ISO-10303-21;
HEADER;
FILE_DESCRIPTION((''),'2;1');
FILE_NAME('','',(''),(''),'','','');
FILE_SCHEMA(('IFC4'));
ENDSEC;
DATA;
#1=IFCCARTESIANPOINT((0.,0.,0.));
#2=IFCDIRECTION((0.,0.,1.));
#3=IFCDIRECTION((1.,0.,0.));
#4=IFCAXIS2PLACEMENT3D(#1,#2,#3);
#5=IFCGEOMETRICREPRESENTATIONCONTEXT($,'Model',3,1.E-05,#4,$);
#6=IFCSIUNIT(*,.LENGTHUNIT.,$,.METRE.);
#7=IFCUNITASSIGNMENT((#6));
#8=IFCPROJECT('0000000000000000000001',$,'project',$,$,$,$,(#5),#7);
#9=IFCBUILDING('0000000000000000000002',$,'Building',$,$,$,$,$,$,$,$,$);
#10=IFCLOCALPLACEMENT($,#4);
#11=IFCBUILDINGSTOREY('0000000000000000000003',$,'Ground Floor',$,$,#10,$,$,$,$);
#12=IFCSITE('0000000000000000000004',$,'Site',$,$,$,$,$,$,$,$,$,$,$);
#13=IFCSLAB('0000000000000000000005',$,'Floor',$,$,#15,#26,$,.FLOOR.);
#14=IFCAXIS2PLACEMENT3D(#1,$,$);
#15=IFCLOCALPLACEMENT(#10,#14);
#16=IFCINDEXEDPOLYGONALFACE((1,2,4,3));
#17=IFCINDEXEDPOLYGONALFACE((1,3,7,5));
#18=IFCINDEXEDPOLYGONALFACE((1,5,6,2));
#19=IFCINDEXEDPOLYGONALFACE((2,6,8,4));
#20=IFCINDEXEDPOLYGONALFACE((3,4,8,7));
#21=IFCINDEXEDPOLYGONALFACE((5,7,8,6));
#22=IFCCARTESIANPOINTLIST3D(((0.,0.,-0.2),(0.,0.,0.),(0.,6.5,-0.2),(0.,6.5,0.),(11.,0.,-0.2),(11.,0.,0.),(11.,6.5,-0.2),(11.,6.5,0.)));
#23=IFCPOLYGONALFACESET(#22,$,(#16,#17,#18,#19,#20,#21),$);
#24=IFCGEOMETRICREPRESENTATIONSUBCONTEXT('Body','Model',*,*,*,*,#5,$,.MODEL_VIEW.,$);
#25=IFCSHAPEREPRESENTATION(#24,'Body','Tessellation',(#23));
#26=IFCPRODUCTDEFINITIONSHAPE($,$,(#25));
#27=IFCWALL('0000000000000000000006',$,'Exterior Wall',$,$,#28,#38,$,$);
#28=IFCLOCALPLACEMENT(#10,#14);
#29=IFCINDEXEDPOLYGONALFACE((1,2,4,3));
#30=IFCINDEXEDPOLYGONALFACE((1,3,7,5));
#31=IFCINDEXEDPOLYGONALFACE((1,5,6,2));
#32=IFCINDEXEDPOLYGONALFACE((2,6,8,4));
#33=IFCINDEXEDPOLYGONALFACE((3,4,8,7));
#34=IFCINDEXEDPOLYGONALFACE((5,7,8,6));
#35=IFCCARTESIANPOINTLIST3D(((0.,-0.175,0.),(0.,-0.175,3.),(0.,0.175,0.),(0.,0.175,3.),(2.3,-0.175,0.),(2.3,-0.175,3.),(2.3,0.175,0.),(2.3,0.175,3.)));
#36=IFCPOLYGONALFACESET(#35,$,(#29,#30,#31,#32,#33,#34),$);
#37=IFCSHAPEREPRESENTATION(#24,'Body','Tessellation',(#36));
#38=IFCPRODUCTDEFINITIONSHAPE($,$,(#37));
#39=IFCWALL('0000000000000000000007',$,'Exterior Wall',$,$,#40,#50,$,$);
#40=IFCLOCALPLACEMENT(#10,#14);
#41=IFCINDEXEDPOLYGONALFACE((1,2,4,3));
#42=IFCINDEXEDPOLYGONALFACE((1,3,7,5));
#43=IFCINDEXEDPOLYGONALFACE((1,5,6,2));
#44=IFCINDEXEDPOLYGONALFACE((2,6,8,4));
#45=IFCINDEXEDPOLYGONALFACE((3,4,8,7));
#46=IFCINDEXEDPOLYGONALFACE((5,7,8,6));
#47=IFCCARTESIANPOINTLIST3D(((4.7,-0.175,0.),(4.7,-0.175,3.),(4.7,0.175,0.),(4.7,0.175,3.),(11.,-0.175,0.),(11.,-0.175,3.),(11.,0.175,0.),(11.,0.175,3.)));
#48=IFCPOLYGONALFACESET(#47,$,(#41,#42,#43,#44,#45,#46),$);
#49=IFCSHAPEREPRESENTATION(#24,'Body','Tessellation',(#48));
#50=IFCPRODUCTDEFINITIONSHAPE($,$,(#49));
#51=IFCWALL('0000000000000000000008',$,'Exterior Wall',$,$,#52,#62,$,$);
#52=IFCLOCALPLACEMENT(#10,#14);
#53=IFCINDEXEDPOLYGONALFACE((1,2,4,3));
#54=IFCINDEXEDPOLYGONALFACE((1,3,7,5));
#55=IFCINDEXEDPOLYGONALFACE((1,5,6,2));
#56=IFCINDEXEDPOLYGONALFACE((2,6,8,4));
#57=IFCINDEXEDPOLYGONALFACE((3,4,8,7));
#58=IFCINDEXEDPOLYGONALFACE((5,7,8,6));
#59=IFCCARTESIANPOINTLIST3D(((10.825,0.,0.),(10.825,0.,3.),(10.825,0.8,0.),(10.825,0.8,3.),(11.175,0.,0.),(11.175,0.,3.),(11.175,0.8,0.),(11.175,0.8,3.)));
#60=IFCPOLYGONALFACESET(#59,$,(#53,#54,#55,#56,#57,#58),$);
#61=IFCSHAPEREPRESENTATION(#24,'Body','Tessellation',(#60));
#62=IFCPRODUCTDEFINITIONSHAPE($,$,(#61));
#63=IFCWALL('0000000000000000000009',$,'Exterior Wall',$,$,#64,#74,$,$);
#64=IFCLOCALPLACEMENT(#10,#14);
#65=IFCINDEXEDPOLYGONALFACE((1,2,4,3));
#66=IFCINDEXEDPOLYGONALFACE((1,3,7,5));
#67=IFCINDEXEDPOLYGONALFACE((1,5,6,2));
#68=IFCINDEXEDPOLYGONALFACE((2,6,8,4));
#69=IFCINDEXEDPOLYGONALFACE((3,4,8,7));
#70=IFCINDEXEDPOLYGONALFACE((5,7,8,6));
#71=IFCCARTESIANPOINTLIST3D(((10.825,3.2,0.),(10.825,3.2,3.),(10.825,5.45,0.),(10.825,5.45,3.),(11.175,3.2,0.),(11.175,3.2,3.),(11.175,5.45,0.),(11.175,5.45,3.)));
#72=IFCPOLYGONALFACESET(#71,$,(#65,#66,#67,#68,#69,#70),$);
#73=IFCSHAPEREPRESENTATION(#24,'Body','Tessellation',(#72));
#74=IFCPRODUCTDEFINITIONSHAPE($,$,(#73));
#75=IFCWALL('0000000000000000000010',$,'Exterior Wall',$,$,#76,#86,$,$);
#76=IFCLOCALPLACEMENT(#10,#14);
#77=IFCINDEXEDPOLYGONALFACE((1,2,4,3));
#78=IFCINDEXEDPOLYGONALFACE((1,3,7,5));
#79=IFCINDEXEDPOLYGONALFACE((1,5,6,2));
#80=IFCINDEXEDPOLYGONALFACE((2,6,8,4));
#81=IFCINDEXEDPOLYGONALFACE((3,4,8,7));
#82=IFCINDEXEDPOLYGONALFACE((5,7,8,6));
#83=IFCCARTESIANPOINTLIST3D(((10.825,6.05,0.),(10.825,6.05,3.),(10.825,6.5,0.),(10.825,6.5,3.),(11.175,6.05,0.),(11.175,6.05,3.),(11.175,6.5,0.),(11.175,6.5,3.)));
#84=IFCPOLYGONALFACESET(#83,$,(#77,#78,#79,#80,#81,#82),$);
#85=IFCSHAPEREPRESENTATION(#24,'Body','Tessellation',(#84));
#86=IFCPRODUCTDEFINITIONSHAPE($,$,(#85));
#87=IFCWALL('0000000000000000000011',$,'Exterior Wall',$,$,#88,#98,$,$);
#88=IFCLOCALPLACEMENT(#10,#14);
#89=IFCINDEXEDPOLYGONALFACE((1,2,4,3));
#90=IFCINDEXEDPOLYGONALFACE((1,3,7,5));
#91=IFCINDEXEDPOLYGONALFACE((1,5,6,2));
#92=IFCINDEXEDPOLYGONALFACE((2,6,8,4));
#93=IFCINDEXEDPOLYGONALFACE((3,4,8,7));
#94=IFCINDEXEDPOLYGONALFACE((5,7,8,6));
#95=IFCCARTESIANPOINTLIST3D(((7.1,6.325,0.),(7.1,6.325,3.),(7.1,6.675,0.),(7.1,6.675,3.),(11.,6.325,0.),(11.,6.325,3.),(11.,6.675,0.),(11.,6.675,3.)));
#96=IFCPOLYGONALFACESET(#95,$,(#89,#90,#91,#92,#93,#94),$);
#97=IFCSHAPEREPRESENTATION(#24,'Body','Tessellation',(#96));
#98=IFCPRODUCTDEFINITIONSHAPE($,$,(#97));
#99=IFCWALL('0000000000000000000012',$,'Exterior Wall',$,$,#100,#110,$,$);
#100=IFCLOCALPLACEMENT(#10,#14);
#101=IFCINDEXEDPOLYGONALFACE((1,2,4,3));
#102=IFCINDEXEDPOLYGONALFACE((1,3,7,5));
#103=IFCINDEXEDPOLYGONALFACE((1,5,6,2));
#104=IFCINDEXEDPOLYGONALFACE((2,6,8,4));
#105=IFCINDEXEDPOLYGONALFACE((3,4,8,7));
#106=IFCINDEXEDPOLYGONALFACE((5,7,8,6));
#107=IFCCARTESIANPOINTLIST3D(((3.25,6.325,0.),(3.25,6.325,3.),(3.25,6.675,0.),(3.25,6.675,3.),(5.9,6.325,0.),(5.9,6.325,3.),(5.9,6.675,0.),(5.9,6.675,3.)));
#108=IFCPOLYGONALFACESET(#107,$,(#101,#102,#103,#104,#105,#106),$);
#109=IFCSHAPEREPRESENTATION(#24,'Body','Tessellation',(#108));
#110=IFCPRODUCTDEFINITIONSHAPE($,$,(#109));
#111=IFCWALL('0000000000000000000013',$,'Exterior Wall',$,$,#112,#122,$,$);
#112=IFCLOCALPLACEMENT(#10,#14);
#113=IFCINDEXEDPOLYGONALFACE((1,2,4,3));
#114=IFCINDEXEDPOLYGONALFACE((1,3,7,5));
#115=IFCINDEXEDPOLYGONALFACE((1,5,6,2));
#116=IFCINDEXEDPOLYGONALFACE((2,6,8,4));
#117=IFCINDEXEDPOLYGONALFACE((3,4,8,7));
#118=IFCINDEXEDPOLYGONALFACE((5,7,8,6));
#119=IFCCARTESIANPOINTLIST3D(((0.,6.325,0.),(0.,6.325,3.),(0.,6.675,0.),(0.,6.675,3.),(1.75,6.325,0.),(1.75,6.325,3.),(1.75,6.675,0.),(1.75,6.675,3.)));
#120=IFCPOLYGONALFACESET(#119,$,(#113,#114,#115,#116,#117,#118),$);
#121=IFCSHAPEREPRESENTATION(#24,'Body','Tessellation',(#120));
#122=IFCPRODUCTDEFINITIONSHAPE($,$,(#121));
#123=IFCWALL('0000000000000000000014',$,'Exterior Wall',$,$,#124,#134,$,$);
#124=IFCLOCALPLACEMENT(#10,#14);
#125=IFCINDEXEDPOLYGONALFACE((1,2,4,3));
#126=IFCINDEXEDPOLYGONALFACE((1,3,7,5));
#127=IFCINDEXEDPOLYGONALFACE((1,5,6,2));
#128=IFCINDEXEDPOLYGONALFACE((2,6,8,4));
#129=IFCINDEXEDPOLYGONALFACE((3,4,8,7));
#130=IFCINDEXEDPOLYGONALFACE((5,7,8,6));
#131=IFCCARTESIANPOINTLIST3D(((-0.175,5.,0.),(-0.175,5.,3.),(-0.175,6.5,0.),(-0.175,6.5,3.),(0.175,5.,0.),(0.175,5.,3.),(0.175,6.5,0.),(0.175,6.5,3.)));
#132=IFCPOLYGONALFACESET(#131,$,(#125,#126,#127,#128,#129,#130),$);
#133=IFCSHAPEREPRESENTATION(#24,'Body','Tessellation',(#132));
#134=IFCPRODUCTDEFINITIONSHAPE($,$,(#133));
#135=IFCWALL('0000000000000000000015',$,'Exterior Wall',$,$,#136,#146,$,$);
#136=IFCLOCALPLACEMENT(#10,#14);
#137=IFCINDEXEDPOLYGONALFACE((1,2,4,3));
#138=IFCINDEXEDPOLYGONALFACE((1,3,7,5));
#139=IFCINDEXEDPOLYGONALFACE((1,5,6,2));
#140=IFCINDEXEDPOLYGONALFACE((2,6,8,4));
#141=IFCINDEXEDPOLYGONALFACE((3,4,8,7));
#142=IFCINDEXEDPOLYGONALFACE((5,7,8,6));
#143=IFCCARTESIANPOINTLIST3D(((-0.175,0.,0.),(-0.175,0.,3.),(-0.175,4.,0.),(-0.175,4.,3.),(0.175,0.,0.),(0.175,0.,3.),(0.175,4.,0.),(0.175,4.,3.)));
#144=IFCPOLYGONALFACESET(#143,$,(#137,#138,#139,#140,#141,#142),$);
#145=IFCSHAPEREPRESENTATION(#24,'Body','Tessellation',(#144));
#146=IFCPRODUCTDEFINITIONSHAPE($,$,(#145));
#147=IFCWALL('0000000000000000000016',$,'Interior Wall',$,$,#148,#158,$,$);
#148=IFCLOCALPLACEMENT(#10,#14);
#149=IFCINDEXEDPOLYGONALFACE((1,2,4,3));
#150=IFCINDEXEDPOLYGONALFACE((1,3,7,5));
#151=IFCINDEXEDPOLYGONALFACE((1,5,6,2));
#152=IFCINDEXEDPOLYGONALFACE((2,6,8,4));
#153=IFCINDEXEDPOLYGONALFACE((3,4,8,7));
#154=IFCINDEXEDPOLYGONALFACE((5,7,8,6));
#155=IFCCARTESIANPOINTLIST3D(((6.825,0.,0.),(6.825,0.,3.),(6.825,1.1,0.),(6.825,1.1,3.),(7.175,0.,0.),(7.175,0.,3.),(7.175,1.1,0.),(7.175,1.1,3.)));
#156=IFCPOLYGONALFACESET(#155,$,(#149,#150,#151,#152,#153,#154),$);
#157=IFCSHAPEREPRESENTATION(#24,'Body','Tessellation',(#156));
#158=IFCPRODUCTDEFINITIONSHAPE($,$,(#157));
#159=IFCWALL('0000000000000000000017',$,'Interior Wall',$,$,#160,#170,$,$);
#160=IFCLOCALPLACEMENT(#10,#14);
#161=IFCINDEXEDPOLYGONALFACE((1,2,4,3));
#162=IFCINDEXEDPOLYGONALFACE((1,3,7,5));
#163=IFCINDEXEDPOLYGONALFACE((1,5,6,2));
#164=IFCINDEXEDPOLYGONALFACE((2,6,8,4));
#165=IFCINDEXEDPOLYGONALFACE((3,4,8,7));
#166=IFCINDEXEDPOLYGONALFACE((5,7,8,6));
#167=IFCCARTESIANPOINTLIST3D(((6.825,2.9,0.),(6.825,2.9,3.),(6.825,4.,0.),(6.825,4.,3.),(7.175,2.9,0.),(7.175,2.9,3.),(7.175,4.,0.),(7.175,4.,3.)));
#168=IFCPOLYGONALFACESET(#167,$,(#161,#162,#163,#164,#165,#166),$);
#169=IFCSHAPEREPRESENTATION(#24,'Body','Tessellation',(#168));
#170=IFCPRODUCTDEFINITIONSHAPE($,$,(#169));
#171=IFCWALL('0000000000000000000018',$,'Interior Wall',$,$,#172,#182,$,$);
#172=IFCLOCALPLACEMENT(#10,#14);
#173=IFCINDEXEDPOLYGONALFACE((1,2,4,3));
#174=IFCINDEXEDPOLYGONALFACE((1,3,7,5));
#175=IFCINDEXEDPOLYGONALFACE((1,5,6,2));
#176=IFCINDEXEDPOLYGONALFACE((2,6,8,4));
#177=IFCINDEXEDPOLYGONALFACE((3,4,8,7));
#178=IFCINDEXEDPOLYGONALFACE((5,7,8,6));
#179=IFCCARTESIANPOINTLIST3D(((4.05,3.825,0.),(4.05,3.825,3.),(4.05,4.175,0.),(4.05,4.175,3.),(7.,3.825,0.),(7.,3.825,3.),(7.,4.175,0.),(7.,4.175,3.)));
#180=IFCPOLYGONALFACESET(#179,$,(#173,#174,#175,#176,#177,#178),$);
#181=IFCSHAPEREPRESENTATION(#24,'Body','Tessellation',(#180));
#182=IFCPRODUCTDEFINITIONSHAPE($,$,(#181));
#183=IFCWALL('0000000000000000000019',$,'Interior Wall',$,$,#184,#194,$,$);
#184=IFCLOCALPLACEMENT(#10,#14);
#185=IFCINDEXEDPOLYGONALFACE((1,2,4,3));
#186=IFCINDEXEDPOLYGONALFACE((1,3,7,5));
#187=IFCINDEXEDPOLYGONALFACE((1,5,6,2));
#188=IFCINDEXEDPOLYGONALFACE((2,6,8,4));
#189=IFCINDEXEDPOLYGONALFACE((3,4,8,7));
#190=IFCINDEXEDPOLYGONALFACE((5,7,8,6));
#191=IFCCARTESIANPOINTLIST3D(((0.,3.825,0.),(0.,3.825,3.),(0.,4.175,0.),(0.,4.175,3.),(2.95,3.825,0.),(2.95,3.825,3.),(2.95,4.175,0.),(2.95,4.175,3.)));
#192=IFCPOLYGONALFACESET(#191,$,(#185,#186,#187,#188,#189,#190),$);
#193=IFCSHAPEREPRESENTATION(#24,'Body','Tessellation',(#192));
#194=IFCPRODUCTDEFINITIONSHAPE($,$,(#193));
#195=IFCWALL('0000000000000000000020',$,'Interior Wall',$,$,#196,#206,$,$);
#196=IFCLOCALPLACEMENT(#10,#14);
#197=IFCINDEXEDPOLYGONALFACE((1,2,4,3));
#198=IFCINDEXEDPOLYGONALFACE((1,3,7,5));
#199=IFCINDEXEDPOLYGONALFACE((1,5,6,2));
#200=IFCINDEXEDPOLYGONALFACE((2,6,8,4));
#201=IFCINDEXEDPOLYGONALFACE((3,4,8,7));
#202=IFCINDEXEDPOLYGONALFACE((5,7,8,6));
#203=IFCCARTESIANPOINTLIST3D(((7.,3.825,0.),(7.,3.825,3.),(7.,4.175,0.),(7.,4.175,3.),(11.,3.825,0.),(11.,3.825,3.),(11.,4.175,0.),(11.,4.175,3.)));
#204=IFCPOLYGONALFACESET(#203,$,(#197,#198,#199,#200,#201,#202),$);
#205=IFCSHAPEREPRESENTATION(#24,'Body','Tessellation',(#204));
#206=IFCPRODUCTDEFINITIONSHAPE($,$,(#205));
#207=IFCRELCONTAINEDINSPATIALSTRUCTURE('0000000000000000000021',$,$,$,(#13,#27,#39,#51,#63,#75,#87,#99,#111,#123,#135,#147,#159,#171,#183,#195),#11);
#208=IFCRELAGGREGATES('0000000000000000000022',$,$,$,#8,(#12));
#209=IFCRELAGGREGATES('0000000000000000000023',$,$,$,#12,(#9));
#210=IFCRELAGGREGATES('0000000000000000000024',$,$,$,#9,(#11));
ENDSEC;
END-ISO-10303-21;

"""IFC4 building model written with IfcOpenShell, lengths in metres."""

from ifc_helpers import new_model, si_unit, frame, origin_with_axes, place, context, subcontext, project, spatial, indexed_curve, outline, extrude, element, save


model = new_model("IFC4")

# Units and contexts
model_context = context("Model", 3, precision=1e-05, world=origin_with_axes())
body_context = subcontext(model_context, "Body", "Model", "MODEL_VIEW")
ifc_project = project(units=[si_unit("LENGTHUNIT", "METRE")], contexts=[model_context])

# Site, building, storey
site = spatial("IfcSite", under=ifc_project, Name="Site")
building = spatial("IfcBuilding", under=site, Name="Building")
storey_placement = place(None, origin_with_axes())
storey = spatial("IfcBuildingStorey", under=building, at=storey_placement, Name="Ground Floor")

# Slab
slab_placement = place(storey_placement, frame((0.0, 0.0, -0.2), z_axis=(0.0, 0.0, 1.0), x_axis=(1.0, 0.0, 0.0)))
element("IfcSlab", 1, at=slab_placement, inside=storey, Name="Floor", PredefinedType="FLOOR", context=body_context, shape_type="SweptSolid", body=[
    extrude(outline(indexed_curve([(0.0, 0.0), (11.0, 0.0), (11.0, 6.5), (0.0, 6.5)])), None, (0.0, 0.0, 1.0), 0.2),
])

# Walls
wall_1_placement = place(storey_placement, origin_with_axes())
element("IfcWall", 2, at=wall_1_placement, inside=storey, Name="Exterior Wall", context=body_context, shape_type="SweptSolid", body=[
    extrude(outline(indexed_curve([(0.0, 0.0), (0.0, 0.35), (2.3, 0.35), (2.3, 0.0), (0.0, 0.0)], self_intersect=False)), frame((0.0, -0.175, 0.0), z_axis=(0.0, 0.0, 1.0), x_axis=(1.0, 0.0, 0.0)), (0.0, 0.0, 1.0), 3.0),
])
wall_2_placement = place(storey_placement, frame((4.7, 0.0, 0.0), z_axis=(0.0, 0.0, 1.0), x_axis=(1.0, 0.0, 0.0)))
element("IfcWall", 3, at=wall_2_placement, inside=storey, Name="Exterior Wall", context=body_context, shape_type="SweptSolid", body=[
    extrude(outline(indexed_curve([(0.0, 0.0), (0.0, 0.35), (6.3, 0.35), (6.3, 0.0), (0.0, 0.0)], self_intersect=False)), frame((0.0, -0.175, 0.0), z_axis=(0.0, 0.0, 1.0), x_axis=(1.0, 0.0, 0.0)), (0.0, 0.0, 1.0), 3.0),
])
wall_3_placement = place(storey_placement, frame((11.0, 0.0, 0.0), z_axis=(0.0, 0.0, 1.0), x_axis=(0.0, 1.0, 0.0)))
element("IfcWall", 4, at=wall_3_placement, inside=storey, Name="Exterior Wall", context=body_context, shape_type="SweptSolid", body=[
    extrude(outline(indexed_curve([(0.0, 0.0), (0.0, 0.35), (0.8, 0.35), (0.8, 0.0), (0.0, 0.0)], self_intersect=False)), frame((0.0, -0.175, 0.0), z_axis=(0.0, 0.0, 1.0), x_axis=(1.0, 0.0, 0.0)), (0.0, 0.0, 1.0), 3.0),
])
wall_4_placement = place(storey_placement, frame((11.0, 3.2, 0.0), z_axis=(0.0, 0.0, 1.0), x_axis=(0.0, 1.0, 0.0)))
element("IfcWall", 5, at=wall_4_placement, inside=storey, Name="Exterior Wall", context=body_context, shape_type="SweptSolid", body=[
    extrude(outline(indexed_curve([(0.0, 0.0), (0.0, 0.35), (2.25, 0.35), (2.25, 0.0), (0.0, 0.0)], self_intersect=False)), frame((0.0, -0.175, 0.0), z_axis=(0.0, 0.0, 1.0), x_axis=(1.0, 0.0, 0.0)), (0.0, 0.0, 1.0), 3.0),
])
wall_5_placement = place(storey_placement, frame((11.0, 6.05, 0.0), z_axis=(0.0, 0.0, 1.0), x_axis=(0.0, 1.0, 0.0)))
element("IfcWall", 6, at=wall_5_placement, inside=storey, Name="Exterior Wall", context=body_context, shape_type="SweptSolid", body=[
    extrude(outline(indexed_curve([(0.0, 0.0), (0.0, 0.35), (0.45, 0.35), (0.45, 0.0), (0.0, 0.0)], self_intersect=False)), frame((0.0, -0.175, 0.0), z_axis=(0.0, 0.0, 1.0), x_axis=(1.0, 0.0, 0.0)), (0.0, 0.0, 1.0), 3.0),
])
wall_6_placement = place(storey_placement, frame((11.0, 6.5, 0.0), z_axis=(0.0, 0.0, 1.0), x_axis=(-1.0, 0.0, 0.0)))
element("IfcWall", 7, at=wall_6_placement, inside=storey, Name="Exterior Wall", context=body_context, shape_type="SweptSolid", body=[
    extrude(outline(indexed_curve([(0.0, 0.0), (0.0, 0.35), (3.9, 0.35), (3.9, 0.0), (0.0, 0.0)], self_intersect=False)), frame((0.0, -0.175, 0.0), z_axis=(0.0, 0.0, 1.0), x_axis=(1.0, 0.0, 0.0)), (0.0, 0.0, 1.0), 3.0),
])
wall_7_placement = place(storey_placement, frame((5.9, 6.5, 0.0), z_axis=(0.0, 0.0, 1.0), x_axis=(-1.0, 0.0, 0.0)))
element("IfcWall", 8, at=wall_7_placement, inside=storey, Name="Exterior Wall", context=body_context, shape_type="SweptSolid", body=[
    extrude(outline(indexed_curve([(0.0, 0.0), (0.0, 0.35), (2.65, 0.35), (2.65, 0.0), (0.0, 0.0)], self_intersect=False)), frame((0.0, -0.175, 0.0), z_axis=(0.0, 0.0, 1.0), x_axis=(1.0, 0.0, 0.0)), (0.0, 0.0, 1.0), 3.0),
])
wall_8_placement = place(storey_placement, frame((1.75, 6.5, 0.0), z_axis=(0.0, 0.0, 1.0), x_axis=(-1.0, 0.0, 0.0)))
element("IfcWall", 9, at=wall_8_placement, inside=storey, Name="Exterior Wall", context=body_context, shape_type="SweptSolid", body=[
    extrude(outline(indexed_curve([(0.0, 0.0), (0.0, 0.35), (1.75, 0.35), (1.75, 0.0), (0.0, 0.0)], self_intersect=False)), frame((0.0, -0.175, 0.0), z_axis=(0.0, 0.0, 1.0), x_axis=(1.0, 0.0, 0.0)), (0.0, 0.0, 1.0), 3.0),
])
wall_9_placement = place(storey_placement, frame((0.0, 6.5, 0.0), z_axis=(0.0, 0.0, 1.0), x_axis=(0.0, -1.0, 0.0)))
element("IfcWall", 10, at=wall_9_placement, inside=storey, Name="Exterior Wall", context=body_context, shape_type="SweptSolid", body=[
    extrude(outline(indexed_curve([(0.0, 0.0), (0.0, 0.35), (1.5, 0.35), (1.5, 0.0), (0.0, 0.0)], self_intersect=False)), frame((0.0, -0.175, 0.0), z_axis=(0.0, 0.0, 1.0), x_axis=(1.0, 0.0, 0.0)), (0.0, 0.0, 1.0), 3.0),
])
wall_10_placement = place(storey_placement, frame((0.0, 4.0, 0.0), z_axis=(0.0, 0.0, 1.0), x_axis=(0.0, -1.0, 0.0)))
element("IfcWall", 11, at=wall_10_placement, inside=storey, Name="Exterior Wall", context=body_context, shape_type="SweptSolid", body=[
    extrude(outline(indexed_curve([(0.0, 0.0), (0.0, 0.35), (4.0, 0.35), (4.0, 0.0), (0.0, 0.0)], self_intersect=False)), frame((0.0, -0.175, 0.0), z_axis=(0.0, 0.0, 1.0), x_axis=(1.0, 0.0, 0.0)), (0.0, 0.0, 1.0), 3.0),
])
for number, where, z_axis, x_axis, name in (
    (12, (7.0, 0.0, 0.0), (0.0, 0.0, 1.0), (0.0, 1.0, 0.0), "Interior Wall"),
    (13, (7.0, 2.9, 0.0), (0.0, 0.0, 1.0), (0.0, 1.0, 0.0), "Interior Wall"),
):
    element("IfcWall", number, at=place(storey_placement, frame(where, z_axis=z_axis, x_axis=x_axis)), inside=storey, Name=name, context=body_context, shape_type="SweptSolid", body=[
        extrude(outline(indexed_curve([(0.0, 0.0), (0.0, 0.35), (1.1, 0.35), (1.1, 0.0), (0.0, 0.0)], self_intersect=False)), frame((0.0, -0.175, 0.0), z_axis=(0.0, 0.0, 1.0), x_axis=(1.0, 0.0, 0.0)), (0.0, 0.0, 1.0), 3.0),
    ])
for number, where, z_axis, x_axis, name in (
    (14, (7.0, 4.0, 0.0), (0.0, 0.0, 1.0), (-1.0, 0.0, 0.0), "Interior Wall"),
    (15, (2.95, 4.0, 0.0), (0.0, 0.0, 1.0), (-1.0, 0.0, 0.0), "Interior Wall"),
):
    element("IfcWall", number, at=place(storey_placement, frame(where, z_axis=z_axis, x_axis=x_axis)), inside=storey, Name=name, context=body_context, shape_type="SweptSolid", body=[
        extrude(outline(indexed_curve([(0.0, 0.0), (0.0, 0.35), (2.95, 0.35), (2.95, 0.0), (0.0, 0.0)], self_intersect=False)), frame((0.0, -0.175, 0.0), z_axis=(0.0, 0.0, 1.0), x_axis=(1.0, 0.0, 0.0)), (0.0, 0.0, 1.0), 3.0),
    ])
wall_11_placement = place(storey_placement, frame((11.0, 4.0, 0.0), z_axis=(0.0, 0.0, 1.0), x_axis=(-1.0, 0.0, 0.0)))
element("IfcWall", 16, at=wall_11_placement, inside=storey, Name="Interior Wall", context=body_context, shape_type="SweptSolid", body=[
    extrude(outline(indexed_curve([(0.0, 0.0), (0.0, 0.35), (4.0, 0.35), (4.0, 0.0), (0.0, 0.0)], self_intersect=False)), frame((0.0, -0.175, 0.0), z_axis=(0.0, 0.0, 1.0), x_axis=(1.0, 0.0, 0.0)), (0.0, 0.0, 1.0), 3.0),
])

save(model, "model.ifc")
